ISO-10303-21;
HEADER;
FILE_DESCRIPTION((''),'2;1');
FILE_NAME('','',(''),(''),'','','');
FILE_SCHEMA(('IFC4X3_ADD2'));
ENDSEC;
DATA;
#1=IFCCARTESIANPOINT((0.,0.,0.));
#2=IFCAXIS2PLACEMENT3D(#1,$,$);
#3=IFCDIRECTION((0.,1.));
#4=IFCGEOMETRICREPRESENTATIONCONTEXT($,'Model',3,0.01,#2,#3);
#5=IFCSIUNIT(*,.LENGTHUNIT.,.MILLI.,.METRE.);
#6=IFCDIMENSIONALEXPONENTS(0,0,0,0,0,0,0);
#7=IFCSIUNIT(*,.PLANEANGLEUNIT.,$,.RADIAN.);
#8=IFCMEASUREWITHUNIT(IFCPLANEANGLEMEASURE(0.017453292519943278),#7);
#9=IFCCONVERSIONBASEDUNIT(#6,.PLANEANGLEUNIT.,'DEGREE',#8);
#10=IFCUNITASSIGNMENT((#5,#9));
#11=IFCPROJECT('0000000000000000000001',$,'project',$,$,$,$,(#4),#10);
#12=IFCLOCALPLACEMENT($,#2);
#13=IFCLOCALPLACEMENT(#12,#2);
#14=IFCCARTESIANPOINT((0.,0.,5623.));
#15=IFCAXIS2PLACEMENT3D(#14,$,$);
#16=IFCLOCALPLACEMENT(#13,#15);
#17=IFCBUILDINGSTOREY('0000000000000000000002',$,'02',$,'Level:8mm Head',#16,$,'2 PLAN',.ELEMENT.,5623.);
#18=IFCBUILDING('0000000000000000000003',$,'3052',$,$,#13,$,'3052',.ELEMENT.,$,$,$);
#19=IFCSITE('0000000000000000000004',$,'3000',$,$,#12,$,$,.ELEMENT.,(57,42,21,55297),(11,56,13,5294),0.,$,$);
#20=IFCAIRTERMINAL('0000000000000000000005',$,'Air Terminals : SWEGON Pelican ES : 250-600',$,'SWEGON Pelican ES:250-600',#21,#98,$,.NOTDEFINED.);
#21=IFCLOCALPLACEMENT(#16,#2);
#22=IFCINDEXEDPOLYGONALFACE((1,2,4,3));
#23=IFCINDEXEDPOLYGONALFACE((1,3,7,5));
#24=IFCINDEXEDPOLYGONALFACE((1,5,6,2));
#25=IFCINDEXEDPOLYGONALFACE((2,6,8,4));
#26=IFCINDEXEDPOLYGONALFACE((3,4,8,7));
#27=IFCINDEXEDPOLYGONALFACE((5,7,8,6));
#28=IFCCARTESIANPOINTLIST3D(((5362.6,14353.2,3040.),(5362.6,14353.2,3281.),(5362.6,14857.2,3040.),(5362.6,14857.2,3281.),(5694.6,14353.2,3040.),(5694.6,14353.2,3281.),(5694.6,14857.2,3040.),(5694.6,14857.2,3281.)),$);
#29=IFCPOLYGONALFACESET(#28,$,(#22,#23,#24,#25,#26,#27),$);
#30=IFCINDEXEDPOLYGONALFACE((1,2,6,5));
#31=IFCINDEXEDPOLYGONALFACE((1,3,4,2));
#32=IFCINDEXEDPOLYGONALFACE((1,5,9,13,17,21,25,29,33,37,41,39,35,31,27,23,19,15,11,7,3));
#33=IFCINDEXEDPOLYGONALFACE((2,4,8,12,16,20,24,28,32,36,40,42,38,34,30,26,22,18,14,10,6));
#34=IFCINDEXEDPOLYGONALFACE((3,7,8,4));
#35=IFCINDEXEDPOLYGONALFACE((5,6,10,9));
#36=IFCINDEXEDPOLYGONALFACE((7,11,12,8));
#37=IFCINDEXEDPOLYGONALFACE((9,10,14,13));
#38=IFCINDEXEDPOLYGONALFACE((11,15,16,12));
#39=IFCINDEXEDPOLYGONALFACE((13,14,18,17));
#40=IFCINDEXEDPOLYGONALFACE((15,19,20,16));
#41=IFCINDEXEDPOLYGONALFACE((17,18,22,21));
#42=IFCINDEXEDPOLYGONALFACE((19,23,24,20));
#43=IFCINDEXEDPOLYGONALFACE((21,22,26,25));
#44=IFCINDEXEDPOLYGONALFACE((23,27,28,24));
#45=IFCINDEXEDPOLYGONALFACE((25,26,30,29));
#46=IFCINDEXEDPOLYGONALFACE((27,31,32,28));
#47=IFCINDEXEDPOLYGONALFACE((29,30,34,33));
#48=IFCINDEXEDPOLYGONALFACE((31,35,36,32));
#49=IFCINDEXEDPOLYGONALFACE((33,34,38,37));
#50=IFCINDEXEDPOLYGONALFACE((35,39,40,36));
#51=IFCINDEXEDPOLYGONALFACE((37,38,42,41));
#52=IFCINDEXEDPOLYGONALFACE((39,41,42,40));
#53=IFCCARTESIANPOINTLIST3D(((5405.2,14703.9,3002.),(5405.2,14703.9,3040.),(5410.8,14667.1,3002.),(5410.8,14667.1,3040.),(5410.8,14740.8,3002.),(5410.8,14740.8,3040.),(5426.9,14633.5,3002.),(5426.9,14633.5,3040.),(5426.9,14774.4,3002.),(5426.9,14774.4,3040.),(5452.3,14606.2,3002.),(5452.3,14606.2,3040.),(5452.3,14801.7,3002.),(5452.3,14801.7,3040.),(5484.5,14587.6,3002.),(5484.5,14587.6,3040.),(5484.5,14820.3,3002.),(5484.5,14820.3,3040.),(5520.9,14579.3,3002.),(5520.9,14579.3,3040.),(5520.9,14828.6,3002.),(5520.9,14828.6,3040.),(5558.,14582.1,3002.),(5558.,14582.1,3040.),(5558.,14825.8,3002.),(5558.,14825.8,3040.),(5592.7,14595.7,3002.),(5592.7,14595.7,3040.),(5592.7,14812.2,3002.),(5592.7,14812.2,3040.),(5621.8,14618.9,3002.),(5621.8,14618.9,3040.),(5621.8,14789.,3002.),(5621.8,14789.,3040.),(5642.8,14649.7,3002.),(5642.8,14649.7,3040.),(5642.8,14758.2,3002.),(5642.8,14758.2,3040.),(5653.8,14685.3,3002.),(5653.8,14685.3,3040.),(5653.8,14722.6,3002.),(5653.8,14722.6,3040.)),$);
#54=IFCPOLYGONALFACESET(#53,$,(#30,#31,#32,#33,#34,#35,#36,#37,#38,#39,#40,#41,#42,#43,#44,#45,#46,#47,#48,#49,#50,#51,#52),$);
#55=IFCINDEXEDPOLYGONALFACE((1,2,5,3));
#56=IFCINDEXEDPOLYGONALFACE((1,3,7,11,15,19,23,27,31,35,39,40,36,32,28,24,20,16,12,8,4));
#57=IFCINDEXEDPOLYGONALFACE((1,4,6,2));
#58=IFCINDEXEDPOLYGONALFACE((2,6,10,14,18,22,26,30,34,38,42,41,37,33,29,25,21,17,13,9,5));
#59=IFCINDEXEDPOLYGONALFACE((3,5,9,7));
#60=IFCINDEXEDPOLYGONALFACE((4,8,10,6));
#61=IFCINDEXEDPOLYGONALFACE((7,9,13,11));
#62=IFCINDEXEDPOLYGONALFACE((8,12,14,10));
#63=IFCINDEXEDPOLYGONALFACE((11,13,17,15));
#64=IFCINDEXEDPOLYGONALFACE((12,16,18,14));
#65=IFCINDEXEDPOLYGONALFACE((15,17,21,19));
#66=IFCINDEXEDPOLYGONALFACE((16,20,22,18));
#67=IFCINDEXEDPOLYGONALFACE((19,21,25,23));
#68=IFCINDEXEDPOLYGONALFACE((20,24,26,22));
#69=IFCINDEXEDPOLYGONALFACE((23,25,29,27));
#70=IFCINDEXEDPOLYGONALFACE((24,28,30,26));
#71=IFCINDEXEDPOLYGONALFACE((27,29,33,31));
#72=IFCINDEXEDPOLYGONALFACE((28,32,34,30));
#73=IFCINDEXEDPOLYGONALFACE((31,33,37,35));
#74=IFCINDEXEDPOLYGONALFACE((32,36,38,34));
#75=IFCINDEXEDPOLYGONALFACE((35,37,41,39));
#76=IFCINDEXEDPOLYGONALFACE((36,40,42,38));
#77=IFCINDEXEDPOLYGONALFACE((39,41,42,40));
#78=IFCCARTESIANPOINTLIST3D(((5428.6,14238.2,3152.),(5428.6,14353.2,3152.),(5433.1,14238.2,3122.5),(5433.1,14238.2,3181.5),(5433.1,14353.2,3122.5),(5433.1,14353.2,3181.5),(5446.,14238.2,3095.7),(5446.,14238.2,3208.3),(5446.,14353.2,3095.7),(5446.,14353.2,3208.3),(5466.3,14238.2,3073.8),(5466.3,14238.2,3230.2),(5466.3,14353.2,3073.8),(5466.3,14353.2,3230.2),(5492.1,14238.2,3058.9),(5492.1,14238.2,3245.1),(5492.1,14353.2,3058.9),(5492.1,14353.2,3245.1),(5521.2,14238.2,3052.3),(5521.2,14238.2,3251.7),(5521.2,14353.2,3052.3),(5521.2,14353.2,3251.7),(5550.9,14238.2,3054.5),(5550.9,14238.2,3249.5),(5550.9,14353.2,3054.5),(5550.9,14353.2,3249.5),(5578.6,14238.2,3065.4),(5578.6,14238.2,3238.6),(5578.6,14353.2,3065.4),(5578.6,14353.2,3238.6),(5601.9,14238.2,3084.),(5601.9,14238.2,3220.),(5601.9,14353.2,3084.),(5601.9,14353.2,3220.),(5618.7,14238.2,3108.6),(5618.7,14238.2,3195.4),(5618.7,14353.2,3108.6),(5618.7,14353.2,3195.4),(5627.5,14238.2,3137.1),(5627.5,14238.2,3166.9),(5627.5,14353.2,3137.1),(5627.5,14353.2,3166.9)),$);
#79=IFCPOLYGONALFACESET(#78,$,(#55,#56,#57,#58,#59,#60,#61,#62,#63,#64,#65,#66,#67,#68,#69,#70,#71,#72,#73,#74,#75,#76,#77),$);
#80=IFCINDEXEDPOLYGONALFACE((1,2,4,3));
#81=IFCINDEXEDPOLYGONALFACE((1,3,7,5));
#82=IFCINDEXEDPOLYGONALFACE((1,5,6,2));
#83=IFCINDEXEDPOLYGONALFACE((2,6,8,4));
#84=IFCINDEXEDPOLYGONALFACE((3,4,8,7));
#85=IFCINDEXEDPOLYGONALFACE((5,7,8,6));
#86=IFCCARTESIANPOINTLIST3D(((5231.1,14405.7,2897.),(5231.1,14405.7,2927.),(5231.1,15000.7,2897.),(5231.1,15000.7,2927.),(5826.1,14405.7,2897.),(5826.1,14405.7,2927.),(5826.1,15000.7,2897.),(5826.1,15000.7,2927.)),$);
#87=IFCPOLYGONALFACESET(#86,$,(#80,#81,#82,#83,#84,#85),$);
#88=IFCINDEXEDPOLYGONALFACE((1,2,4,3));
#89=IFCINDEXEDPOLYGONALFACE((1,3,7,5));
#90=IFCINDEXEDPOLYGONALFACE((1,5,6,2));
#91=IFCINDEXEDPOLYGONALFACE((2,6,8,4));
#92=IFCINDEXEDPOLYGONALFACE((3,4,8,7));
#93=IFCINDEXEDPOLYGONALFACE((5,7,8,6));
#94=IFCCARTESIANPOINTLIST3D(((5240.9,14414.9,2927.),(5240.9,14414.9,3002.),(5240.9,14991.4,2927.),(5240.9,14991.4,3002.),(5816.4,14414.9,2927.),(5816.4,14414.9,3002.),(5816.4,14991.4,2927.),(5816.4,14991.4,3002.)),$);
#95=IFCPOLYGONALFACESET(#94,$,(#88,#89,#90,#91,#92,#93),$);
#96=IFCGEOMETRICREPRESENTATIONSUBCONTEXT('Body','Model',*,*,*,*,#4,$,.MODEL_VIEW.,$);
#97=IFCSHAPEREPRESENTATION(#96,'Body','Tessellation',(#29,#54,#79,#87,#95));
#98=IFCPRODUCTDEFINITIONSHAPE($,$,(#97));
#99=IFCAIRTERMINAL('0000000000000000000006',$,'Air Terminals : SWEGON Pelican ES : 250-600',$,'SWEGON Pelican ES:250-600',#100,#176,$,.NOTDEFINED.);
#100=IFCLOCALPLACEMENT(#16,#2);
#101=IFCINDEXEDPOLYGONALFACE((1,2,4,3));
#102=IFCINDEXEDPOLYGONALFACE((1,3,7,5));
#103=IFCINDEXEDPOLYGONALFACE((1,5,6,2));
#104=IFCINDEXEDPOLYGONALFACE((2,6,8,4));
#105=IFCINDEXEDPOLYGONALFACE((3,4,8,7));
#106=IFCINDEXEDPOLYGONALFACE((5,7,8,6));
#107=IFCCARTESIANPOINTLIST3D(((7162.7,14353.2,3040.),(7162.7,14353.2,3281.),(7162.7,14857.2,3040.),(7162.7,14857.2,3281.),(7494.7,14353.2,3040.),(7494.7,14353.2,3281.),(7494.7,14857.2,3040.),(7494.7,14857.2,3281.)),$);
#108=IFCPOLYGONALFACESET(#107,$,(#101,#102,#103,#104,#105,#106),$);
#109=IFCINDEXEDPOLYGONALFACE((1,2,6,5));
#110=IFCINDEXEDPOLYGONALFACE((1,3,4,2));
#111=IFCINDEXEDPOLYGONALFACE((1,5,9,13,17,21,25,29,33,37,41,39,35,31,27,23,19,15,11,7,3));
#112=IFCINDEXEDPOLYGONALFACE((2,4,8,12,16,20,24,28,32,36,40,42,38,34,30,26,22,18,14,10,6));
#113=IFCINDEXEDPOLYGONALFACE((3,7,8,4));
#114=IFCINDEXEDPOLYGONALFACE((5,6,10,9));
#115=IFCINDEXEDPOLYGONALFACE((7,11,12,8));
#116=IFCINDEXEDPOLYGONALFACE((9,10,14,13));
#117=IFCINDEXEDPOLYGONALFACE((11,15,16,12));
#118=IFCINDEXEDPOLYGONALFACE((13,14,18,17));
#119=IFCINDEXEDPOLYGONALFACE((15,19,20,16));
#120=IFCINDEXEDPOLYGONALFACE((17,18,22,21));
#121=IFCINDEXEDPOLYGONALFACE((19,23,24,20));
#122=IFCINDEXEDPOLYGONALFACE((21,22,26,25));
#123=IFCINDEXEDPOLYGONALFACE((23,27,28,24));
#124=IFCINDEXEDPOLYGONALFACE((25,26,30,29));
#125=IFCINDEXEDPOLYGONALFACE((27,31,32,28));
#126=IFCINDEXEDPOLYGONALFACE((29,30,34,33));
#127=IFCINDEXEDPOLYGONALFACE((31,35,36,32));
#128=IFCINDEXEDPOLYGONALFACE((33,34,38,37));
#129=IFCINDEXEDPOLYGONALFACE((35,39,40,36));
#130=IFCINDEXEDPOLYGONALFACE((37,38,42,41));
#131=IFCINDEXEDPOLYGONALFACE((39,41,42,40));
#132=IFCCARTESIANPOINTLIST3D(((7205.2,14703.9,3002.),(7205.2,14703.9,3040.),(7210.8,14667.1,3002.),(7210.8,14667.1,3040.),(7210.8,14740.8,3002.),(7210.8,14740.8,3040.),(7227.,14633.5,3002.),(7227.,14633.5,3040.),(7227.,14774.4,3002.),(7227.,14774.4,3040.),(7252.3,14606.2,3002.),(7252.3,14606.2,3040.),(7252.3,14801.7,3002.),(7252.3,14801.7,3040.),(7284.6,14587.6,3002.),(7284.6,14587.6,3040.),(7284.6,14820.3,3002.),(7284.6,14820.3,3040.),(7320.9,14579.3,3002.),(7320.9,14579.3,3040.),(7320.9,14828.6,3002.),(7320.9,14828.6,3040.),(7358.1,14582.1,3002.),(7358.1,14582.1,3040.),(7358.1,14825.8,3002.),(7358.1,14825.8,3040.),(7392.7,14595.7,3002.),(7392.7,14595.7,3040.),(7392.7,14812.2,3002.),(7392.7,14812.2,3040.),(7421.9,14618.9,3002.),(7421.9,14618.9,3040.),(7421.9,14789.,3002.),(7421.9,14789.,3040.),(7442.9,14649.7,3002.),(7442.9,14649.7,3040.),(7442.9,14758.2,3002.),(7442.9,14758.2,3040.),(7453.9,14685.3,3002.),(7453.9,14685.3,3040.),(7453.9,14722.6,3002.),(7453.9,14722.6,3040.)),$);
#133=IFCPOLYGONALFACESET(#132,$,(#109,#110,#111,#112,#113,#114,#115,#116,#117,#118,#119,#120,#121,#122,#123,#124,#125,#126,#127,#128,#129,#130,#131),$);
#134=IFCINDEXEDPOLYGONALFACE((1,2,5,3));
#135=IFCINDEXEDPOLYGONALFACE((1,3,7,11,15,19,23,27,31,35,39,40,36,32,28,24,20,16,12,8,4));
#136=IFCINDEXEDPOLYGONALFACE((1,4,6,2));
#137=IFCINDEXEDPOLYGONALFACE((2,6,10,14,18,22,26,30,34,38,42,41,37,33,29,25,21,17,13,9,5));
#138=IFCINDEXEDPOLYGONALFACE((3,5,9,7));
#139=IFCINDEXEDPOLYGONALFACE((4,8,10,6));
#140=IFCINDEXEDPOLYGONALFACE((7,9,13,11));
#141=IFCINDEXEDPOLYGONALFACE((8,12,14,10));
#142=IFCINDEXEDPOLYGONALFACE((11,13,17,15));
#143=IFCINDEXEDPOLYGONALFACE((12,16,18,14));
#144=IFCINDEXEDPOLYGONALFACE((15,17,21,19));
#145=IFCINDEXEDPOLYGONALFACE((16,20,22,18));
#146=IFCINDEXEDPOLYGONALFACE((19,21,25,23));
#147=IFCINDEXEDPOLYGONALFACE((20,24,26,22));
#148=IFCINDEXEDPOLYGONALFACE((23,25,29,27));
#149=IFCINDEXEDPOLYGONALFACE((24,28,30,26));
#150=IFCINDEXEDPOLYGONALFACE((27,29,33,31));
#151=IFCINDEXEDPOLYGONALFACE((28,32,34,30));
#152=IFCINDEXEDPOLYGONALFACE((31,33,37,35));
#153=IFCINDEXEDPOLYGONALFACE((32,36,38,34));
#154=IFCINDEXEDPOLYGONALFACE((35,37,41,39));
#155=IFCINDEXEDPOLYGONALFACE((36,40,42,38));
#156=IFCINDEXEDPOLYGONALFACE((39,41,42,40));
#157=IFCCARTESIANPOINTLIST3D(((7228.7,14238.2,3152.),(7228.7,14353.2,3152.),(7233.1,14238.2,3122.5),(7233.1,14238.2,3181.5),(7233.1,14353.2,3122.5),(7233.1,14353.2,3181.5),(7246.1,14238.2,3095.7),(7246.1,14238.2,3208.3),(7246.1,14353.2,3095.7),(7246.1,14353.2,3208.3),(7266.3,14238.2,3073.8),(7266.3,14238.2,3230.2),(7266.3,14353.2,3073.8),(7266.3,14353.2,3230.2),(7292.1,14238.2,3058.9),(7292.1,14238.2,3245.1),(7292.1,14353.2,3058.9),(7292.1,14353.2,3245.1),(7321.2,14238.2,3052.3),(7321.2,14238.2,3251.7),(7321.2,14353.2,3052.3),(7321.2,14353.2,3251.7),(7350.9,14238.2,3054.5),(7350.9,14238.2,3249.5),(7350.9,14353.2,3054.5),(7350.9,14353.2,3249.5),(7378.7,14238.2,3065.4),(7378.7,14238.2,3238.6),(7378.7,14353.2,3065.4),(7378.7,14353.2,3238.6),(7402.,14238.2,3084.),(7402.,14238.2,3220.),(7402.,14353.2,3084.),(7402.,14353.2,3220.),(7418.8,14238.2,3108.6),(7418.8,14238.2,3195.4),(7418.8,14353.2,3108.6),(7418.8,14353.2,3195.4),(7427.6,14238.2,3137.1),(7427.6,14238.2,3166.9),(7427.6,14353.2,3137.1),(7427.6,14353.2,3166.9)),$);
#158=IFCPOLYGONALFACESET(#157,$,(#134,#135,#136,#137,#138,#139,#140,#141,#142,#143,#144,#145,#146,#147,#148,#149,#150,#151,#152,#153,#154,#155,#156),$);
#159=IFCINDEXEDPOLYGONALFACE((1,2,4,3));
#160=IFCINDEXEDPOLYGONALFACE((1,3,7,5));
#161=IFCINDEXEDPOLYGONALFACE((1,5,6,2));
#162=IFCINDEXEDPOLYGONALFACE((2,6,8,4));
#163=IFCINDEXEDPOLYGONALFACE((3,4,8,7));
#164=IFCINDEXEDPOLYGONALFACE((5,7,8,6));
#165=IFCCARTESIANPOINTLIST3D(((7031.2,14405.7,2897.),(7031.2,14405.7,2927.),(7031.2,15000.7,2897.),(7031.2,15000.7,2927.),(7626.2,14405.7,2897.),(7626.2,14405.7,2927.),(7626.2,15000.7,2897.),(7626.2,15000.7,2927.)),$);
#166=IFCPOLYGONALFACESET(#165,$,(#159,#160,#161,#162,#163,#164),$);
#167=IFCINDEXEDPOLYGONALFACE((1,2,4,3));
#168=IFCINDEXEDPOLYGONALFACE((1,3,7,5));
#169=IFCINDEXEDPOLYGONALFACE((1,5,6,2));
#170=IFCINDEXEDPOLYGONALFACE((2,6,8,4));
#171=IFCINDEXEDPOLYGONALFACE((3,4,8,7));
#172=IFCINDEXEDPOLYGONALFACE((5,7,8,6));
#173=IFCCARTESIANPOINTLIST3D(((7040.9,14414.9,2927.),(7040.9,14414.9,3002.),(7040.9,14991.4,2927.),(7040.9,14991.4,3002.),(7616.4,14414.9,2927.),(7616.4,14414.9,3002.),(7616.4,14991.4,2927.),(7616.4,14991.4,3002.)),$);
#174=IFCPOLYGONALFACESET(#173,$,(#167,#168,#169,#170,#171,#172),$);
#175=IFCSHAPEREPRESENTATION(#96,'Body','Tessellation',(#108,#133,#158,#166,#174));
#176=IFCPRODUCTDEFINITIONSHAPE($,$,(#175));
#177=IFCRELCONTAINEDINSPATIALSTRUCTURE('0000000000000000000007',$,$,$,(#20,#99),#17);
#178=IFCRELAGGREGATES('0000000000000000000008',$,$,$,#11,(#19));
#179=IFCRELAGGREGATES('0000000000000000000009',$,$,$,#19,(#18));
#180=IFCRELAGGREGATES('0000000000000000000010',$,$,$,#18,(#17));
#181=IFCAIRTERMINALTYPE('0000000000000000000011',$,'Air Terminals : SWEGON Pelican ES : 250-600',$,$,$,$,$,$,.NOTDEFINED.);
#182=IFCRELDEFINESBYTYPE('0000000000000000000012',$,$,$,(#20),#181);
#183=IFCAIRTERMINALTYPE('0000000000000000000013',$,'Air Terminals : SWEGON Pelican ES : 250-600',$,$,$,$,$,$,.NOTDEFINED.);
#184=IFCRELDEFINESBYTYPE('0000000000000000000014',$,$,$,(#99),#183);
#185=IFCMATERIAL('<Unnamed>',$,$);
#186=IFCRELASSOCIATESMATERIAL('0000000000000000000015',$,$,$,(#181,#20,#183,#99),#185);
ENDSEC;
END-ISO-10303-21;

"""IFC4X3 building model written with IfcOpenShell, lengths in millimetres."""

from ifc_helpers import new_model, entity, si_unit, converted_unit, direction, frame, frame_2d, origin, origin_2d_with_axis, place, context, subcontext, project, spatial, rectangle, circle, extrude, source, transform, mapped, material, type_object, type_shapes, element, save


model = new_model("IFC4X3")

# Units and contexts
model_context = context("Model", 3, precision=0.01, world=origin(), true_north=direction((0.0, 1.0)))
body_context = subcontext(model_context, "Body", "Model", "MODEL_VIEW")
ifc_project = project(units=[si_unit("LENGTHUNIT", "METRE", prefix="MILLI"), converted_unit("PLANEANGLEUNIT", "DEGREE", entity("IfcPlaneAngleMeasure", 0.017453292519943278), si_unit("PLANEANGLEUNIT", "RADIAN"), dimensions=[0, 0, 0, 0, 0, 0, 0])], contexts=[model_context])

# Site, building, storey
site_placement = place(None, origin())
site = spatial("IfcSite", under=ifc_project, at=site_placement, Name="3000", CompositionType="ELEMENT", RefLatitude=(57, 42, 21, 55297), RefLongitude=(11, 56, 13, 5294), RefElevation=0.0)
building_placement = place(site_placement, origin())
building = spatial("IfcBuilding", under=site, at=building_placement, Name="3052", LongName="3052", CompositionType="ELEMENT")
storey_placement = place(building_placement, frame((0.0, 0.0, 5623.0)))
storey = spatial("IfcBuildingStorey", under=building, at=storey_placement, Name="02", ObjectType="Level:8mm Head", LongName="2 PLAN", CompositionType="ELEMENT", Elevation=5623.0)

# Air terminals
ifc_material_1 = material(Name="<Unnamed>")
air_terminal_type_1 = type_object("IfcAirTerminalType", Name="Air Terminals : SWEGON Pelican ES : 250-600", PredefinedType="NOTDEFINED", material=ifc_material_1)
shared_shape_1 = source(origin(), body_context, "Body", "SweptSolid", [
    extrude(rectangle(XDim=504.0, YDim=332.0, at=origin_2d_with_axis()), frame((0.0, -98.0, -354.0), z_axis=(0.0, 0.0, 1.0), x_axis=(0.0, 1.0, 0.0)), (0.0, 0.0, 1.0), 241.0),
    extrude(circle(Radius=125.0, at=frame_2d((0.0, 0.0), x_axis=(1.0, 0.0))), frame((-1.6, 0.8, -113.0)), (0.0, 0.0, 1.0), 38.0),
    extrude(circle(Radius=100.0, at=frame_2d((0.0, 0.0), x_axis=(1.0, 0.0))), frame((0.0, -465.0, -225.0), z_axis=(0.0, 1.0, 0.0), x_axis=(1.0, 0.0, 0.0)), (0.0, 0.0, 1.0), 115.0),
    extrude(rectangle(XDim=595.0, YDim=595.0, at=frame_2d((0.0, 0.0), x_axis=(1.0, 0.0))), frame((0.0, 0.0, 0.0), z_axis=(0.0, 0.0, 1.0), x_axis=(0.0, 1.0, 0.0)), (0.0, 0.0, 1.0), 30.0),
    extrude(rectangle(XDim=576.5, YDim=575.5, at=origin_2d_with_axis()), frame((0.0, 0.0, -75.0), z_axis=(0.0, 0.0, 1.0), x_axis=(0.0, 1.0, 0.0)), (0.0, 0.0, 1.0), 75.0),
])
type_shapes(air_terminal_type_1, [shared_shape_1])
air_terminal_1_placement = place(storey_placement, frame((5528.6, 14703.2, 2927.0), z_axis=(0.0, 0.0, -1.0), x_axis=(-1.0, 0.0, 0.0)))
element("IfcAirTerminal", 1, at=air_terminal_1_placement, inside=storey, type_object=air_terminal_type_1, material=ifc_material_1, Name="Air Terminals : SWEGON Pelican ES : 250-600", ObjectType="SWEGON Pelican ES:250-600", PredefinedType="NOTDEFINED", context=body_context, shape_type="MappedRepresentation", body=[
    mapped(shared_shape_1, transform((0.0, 0.0, 0.0), scale=1.0)),
])
air_terminal_type_2 = type_object("IfcAirTerminalType", Name="Air Terminals : SWEGON Pelican ES : 250-600", PredefinedType="NOTDEFINED", material=ifc_material_1)
shared_shape_2 = source(origin(), body_context, "Body", "SweptSolid", [
    extrude(rectangle(XDim=504.0, YDim=332.0, at=origin_2d_with_axis()), frame((0.0, -98.0, -354.0), z_axis=(0.0, 0.0, 1.0), x_axis=(0.0, 1.0, 0.0)), (0.0, 0.0, 1.0), 241.0),
    extrude(circle(Radius=125.0, at=frame_2d((0.0, 0.0), x_axis=(1.0, 0.0))), frame((-1.6, 0.8, -113.0)), (0.0, 0.0, 1.0), 38.0),
    extrude(circle(Radius=100.0, at=frame_2d((0.0, 0.0), x_axis=(1.0, 0.0))), frame((0.0, -465.0, -225.0), z_axis=(0.0, 1.0, 0.0), x_axis=(1.0, 0.0, 0.0)), (0.0, 0.0, 1.0), 115.0),
    extrude(rectangle(XDim=595.0, YDim=595.0, at=frame_2d((0.0, 0.0), x_axis=(1.0, 0.0))), frame((0.0, 0.0, 0.0), z_axis=(0.0, 0.0, 1.0), x_axis=(0.0, 1.0, 0.0)), (0.0, 0.0, 1.0), 30.0),
    extrude(rectangle(XDim=576.5, YDim=575.5, at=origin_2d_with_axis()), frame((0.0, 0.0, -75.0), z_axis=(0.0, 0.0, 1.0), x_axis=(0.0, 1.0, 0.0)), (0.0, 0.0, 1.0), 75.0),
])
type_shapes(air_terminal_type_2, [shared_shape_2])
for number, where, z_axis, x_axis, name in (
    (2, (7328.7, 14703.2, 2927.0), (0.0, 0.0, -1.0), (-1.0, 0.0, 0.0), "Air Terminals : SWEGON Pelican ES : 250-600"),
):
    element("IfcAirTerminal", number, at=place(storey_placement, frame(where, z_axis=z_axis, x_axis=x_axis)), inside=storey, type_object=air_terminal_type_2, material=ifc_material_1, Name=name, ObjectType="SWEGON Pelican ES:250-600", PredefinedType="NOTDEFINED", context=body_context, shape_type="MappedRepresentation", body=[
        mapped(shared_shape_2, transform((0.0, 0.0, 0.0), scale=1.0)),
    ])

save(model, "model.ifc")
